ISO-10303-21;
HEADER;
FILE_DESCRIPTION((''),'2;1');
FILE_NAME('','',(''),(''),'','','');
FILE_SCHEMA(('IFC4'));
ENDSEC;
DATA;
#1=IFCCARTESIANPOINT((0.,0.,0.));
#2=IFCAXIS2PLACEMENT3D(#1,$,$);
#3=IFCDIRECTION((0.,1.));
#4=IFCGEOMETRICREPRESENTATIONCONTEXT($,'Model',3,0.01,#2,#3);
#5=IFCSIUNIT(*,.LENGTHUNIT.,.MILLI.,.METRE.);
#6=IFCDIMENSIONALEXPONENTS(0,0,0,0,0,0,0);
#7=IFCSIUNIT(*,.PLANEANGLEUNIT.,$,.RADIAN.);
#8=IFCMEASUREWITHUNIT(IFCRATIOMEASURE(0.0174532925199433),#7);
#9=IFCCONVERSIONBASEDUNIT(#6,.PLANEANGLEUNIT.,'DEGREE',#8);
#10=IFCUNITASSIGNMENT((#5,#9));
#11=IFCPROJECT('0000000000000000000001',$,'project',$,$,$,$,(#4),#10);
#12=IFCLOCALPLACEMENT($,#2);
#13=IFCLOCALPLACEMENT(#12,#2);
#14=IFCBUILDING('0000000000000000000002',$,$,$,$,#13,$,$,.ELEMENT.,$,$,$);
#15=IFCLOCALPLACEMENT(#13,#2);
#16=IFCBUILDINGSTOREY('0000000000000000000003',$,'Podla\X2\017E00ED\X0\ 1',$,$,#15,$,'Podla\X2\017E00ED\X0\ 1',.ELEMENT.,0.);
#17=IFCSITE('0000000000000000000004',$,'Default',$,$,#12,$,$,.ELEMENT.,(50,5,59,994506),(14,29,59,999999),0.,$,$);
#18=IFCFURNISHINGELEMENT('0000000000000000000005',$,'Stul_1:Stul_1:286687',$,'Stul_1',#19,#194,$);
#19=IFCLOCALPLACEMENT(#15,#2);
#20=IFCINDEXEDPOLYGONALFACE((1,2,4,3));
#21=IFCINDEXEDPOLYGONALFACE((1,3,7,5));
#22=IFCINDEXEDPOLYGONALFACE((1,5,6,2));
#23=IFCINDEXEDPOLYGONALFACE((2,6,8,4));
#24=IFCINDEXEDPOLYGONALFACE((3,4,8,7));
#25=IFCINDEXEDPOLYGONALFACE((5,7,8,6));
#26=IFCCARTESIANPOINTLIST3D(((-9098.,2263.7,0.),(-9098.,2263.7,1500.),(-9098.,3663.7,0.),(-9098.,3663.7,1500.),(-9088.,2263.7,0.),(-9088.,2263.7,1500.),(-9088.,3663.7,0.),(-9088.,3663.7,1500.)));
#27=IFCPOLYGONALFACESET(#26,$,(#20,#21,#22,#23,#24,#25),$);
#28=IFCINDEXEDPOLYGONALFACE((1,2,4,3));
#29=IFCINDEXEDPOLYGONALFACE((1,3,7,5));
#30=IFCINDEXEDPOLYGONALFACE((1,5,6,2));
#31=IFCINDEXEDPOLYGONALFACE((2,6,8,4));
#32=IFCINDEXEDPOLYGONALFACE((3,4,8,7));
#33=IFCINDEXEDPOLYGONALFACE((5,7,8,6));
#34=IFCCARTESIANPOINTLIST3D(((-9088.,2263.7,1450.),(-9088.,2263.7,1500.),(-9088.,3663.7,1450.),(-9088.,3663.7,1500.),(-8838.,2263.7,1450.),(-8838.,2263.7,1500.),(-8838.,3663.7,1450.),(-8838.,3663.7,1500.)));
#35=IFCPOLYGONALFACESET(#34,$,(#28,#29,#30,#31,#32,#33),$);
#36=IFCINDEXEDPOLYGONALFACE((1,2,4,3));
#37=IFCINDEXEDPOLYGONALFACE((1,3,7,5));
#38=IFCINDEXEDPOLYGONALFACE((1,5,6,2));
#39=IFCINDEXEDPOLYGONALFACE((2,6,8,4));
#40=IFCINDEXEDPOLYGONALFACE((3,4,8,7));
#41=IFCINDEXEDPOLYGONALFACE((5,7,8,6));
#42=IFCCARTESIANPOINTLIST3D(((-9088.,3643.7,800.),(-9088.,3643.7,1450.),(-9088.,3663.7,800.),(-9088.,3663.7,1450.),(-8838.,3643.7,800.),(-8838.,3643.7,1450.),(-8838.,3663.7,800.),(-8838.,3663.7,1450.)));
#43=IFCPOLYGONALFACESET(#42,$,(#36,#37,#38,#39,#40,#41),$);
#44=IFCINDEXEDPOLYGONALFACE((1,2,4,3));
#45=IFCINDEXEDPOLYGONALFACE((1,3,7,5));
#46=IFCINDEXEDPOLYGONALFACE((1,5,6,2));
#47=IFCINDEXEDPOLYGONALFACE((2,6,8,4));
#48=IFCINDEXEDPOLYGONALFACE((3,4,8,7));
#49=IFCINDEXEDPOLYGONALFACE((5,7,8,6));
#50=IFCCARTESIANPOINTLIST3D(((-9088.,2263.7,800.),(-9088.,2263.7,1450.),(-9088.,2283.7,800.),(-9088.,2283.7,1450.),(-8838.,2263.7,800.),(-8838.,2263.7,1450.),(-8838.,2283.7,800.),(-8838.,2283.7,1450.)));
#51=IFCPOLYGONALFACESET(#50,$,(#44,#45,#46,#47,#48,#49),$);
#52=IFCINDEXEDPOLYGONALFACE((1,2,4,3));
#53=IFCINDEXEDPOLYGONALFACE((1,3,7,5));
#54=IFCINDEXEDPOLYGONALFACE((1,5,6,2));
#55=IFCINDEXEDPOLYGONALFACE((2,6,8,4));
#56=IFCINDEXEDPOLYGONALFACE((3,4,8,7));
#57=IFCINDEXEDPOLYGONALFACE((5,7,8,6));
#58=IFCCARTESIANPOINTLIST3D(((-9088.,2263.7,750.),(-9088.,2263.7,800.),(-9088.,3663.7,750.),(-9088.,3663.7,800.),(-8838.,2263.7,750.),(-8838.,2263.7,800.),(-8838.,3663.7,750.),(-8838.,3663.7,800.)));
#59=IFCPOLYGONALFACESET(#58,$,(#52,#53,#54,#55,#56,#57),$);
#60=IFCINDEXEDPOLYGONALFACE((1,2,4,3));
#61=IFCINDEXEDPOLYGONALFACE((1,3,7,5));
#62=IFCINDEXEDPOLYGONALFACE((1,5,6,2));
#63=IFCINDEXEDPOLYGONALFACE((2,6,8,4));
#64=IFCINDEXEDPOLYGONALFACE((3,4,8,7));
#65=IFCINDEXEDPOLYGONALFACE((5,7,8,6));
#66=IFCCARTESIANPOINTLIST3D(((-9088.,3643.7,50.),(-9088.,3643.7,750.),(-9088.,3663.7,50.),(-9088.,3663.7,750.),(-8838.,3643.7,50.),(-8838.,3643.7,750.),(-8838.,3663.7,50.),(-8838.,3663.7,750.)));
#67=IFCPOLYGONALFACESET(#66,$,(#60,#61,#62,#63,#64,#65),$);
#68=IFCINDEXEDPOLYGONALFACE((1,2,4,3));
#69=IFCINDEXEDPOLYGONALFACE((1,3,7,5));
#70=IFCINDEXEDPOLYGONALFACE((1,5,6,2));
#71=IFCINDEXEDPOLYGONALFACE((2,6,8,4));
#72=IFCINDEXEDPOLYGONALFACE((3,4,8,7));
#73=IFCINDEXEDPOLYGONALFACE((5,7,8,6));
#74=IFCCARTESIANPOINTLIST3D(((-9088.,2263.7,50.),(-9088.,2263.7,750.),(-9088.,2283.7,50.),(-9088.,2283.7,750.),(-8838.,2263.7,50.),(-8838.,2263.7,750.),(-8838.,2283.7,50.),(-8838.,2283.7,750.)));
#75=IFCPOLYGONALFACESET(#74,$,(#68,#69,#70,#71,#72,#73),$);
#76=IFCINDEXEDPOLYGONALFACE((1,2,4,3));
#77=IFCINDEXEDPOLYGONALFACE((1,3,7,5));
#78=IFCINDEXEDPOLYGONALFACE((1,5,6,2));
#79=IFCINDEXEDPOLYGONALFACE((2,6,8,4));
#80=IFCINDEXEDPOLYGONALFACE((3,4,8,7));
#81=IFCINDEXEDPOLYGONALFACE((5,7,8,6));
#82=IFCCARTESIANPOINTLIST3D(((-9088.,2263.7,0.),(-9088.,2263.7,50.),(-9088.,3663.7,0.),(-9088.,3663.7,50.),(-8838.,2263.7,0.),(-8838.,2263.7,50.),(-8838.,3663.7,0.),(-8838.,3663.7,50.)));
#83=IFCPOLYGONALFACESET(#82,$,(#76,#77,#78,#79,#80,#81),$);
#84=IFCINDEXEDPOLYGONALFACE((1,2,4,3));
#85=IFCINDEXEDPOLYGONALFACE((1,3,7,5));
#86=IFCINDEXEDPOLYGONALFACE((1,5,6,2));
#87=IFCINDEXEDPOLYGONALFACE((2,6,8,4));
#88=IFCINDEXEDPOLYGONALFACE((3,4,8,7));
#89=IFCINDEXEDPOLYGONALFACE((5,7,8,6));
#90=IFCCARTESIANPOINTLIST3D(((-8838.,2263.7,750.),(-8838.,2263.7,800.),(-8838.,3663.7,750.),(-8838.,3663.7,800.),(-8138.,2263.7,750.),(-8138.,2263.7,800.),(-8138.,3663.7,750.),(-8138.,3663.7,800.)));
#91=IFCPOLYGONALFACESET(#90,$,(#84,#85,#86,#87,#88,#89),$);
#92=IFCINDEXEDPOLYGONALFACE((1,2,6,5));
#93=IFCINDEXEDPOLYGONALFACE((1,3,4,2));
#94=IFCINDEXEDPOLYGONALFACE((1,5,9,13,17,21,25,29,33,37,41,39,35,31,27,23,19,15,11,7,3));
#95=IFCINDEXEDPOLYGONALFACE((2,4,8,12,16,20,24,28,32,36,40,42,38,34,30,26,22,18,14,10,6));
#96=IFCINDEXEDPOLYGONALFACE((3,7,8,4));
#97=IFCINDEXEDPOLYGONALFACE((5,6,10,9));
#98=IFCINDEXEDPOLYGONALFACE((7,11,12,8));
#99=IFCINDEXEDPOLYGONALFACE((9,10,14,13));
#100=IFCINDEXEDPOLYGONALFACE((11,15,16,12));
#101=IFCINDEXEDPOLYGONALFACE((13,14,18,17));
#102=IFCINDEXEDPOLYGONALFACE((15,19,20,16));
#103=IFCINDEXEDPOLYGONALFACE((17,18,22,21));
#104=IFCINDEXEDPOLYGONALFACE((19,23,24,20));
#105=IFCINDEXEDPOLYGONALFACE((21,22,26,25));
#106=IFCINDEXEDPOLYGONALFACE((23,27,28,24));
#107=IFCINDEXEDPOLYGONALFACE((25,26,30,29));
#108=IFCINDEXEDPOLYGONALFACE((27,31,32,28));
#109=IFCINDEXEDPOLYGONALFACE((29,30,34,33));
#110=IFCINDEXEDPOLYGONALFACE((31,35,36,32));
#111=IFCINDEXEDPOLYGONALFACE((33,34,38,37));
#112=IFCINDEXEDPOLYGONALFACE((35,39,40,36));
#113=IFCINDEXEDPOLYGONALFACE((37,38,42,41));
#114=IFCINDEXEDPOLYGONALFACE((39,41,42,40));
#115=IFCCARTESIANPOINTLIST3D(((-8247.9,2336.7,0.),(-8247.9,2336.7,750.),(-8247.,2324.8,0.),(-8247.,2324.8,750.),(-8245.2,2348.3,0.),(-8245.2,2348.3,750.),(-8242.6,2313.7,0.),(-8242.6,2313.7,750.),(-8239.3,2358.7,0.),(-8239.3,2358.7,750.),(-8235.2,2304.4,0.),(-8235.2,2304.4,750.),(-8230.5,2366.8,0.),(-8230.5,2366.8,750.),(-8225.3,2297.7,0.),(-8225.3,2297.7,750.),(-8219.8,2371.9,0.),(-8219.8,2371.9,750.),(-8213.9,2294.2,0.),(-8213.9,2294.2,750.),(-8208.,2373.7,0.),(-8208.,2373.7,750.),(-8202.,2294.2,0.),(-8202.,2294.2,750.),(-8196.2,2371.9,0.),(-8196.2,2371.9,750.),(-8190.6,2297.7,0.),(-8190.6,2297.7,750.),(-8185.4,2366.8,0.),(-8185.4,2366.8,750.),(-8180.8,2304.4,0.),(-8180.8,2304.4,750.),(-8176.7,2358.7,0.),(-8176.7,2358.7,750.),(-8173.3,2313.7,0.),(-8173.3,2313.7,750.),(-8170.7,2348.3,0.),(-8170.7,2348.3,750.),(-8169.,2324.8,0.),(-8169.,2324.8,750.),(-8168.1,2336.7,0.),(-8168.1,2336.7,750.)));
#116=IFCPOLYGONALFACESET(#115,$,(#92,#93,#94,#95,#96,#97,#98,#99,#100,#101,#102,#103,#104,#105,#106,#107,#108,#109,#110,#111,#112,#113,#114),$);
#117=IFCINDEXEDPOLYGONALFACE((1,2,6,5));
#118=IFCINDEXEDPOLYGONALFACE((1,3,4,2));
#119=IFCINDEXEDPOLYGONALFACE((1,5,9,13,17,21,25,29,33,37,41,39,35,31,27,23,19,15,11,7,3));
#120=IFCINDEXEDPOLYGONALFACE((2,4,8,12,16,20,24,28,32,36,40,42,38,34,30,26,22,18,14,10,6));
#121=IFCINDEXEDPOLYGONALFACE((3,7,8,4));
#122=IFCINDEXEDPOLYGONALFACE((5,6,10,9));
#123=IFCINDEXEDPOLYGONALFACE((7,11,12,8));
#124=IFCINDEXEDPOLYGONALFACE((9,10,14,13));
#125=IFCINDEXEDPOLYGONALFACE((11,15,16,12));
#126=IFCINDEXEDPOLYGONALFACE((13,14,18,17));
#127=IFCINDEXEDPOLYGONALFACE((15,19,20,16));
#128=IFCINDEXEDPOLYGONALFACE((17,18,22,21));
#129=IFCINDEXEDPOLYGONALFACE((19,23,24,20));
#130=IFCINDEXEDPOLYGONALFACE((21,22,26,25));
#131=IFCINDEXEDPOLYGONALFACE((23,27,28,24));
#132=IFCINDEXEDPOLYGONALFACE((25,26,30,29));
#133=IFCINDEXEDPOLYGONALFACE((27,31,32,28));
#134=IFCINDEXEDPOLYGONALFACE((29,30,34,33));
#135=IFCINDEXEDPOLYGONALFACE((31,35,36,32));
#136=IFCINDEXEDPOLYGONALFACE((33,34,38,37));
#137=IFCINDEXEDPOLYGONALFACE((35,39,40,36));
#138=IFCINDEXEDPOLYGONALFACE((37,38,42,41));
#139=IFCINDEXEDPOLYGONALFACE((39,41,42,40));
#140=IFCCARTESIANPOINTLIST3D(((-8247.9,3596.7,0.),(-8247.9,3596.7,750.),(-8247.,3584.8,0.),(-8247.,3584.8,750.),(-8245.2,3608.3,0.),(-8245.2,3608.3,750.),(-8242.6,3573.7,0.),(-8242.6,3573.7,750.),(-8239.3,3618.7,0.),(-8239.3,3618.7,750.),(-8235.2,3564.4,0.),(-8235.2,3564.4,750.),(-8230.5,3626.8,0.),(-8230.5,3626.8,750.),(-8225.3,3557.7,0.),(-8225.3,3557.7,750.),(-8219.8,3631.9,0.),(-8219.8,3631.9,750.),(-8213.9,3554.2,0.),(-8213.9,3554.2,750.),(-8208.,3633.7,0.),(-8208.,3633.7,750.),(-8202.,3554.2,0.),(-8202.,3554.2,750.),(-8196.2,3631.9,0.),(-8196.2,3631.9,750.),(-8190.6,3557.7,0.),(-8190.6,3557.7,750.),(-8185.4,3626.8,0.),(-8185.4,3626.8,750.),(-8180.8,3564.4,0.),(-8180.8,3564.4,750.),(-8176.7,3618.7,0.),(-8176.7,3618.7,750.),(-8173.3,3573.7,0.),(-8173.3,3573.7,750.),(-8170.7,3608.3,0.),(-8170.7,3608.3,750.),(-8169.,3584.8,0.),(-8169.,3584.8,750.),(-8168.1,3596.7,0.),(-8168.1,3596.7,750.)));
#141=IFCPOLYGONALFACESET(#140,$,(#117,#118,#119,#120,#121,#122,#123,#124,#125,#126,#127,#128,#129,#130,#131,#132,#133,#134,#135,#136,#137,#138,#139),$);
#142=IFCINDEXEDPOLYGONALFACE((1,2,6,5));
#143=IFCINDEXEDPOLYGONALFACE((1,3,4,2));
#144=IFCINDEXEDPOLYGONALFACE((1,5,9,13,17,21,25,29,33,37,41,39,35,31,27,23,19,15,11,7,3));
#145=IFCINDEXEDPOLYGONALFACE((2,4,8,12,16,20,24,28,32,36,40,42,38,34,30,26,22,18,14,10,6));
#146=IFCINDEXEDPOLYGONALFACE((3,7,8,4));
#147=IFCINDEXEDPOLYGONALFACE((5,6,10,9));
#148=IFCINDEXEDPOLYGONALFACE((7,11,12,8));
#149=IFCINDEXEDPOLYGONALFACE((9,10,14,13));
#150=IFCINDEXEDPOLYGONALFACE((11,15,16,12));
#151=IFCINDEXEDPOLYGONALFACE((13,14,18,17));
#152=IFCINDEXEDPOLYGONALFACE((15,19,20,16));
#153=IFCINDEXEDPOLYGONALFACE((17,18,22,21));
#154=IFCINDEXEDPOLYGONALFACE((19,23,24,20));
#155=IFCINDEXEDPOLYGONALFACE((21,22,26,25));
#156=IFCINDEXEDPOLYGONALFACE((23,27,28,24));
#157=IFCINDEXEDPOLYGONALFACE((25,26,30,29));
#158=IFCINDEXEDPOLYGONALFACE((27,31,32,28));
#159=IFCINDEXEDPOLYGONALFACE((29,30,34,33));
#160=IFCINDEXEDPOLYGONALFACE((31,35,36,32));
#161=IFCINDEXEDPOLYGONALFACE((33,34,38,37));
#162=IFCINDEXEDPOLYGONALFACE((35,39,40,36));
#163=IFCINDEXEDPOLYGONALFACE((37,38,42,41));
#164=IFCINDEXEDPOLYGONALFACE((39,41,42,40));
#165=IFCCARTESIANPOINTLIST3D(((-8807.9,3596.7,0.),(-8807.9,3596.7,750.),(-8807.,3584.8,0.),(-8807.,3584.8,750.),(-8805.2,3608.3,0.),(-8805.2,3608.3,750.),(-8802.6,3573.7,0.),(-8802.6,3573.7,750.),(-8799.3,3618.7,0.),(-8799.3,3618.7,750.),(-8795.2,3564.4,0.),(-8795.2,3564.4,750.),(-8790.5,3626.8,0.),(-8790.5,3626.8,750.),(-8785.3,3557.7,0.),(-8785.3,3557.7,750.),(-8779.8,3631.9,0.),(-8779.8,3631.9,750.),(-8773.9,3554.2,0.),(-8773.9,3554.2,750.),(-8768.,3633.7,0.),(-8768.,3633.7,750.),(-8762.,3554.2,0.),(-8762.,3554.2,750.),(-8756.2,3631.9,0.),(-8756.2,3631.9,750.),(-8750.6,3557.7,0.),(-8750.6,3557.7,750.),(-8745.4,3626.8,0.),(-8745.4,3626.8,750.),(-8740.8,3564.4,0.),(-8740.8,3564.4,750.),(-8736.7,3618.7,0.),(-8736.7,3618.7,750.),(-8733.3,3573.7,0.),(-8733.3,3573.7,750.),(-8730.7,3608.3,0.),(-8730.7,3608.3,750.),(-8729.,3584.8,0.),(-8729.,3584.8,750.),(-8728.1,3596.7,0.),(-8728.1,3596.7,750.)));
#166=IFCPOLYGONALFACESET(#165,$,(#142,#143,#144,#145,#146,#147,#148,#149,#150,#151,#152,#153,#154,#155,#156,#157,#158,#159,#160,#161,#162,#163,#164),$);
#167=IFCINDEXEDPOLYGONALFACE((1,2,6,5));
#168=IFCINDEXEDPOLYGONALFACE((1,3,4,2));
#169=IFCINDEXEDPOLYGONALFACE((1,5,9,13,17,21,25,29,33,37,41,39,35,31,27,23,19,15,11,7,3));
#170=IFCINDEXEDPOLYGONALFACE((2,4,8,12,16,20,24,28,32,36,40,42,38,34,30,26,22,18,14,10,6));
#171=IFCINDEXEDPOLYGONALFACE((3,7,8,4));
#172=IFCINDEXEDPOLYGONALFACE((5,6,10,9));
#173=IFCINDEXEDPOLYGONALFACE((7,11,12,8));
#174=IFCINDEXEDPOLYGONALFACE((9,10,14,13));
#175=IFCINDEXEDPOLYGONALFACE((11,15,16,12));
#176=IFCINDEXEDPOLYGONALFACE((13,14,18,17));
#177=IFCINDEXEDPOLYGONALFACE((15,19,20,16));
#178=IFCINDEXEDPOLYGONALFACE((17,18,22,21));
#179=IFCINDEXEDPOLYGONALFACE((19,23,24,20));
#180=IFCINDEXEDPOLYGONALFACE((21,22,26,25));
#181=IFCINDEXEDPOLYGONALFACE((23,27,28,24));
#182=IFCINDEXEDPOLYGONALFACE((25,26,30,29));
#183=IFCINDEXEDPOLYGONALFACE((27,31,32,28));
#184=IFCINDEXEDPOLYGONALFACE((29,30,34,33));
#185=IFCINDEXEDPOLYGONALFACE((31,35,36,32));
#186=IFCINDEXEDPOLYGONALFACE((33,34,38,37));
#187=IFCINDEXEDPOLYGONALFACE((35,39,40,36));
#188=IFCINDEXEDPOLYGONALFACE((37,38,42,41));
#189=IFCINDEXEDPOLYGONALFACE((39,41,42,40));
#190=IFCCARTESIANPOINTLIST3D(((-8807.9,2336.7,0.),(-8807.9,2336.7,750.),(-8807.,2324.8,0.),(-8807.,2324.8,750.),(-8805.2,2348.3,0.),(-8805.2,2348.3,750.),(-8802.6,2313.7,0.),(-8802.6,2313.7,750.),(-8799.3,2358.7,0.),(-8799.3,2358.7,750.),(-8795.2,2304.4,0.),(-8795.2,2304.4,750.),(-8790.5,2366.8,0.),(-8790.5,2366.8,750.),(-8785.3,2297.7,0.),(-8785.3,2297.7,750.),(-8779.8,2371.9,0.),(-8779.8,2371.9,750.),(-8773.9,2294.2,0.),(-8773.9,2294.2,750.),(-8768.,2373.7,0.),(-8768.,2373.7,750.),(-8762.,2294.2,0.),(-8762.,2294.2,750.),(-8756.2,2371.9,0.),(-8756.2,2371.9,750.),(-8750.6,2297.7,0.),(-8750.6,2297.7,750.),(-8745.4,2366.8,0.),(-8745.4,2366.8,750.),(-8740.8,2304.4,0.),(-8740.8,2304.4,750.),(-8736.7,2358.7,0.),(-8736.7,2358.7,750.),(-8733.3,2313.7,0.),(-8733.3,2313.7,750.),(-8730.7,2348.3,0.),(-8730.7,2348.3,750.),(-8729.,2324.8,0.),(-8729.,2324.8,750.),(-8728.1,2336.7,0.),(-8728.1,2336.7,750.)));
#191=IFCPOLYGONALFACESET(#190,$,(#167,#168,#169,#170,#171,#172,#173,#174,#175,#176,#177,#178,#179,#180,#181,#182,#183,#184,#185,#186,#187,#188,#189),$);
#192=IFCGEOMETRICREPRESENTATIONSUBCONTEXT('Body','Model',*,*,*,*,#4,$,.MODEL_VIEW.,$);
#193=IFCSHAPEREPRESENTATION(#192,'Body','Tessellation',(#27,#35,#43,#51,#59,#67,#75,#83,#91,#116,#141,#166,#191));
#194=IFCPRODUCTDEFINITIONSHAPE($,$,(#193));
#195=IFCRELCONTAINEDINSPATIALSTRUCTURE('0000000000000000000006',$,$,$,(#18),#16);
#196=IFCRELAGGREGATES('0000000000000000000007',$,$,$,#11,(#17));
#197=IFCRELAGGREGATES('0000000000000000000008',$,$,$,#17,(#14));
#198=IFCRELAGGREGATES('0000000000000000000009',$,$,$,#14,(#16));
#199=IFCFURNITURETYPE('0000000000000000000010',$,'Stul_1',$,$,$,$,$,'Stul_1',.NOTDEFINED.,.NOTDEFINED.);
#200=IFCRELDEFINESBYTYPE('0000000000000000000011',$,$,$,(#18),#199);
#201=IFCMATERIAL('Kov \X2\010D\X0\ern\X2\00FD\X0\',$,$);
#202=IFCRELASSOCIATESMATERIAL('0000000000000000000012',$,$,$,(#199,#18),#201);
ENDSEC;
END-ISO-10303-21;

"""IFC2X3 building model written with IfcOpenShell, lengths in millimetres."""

from ifc_helpers import new_model, entity, si_unit, converted_unit, direction, frame, frame_2d, origin, origin_2d_with_axis, place, context, subcontext, project, spatial, rectangle, circle, extrude, source, transform, mapped, material, type_object, type_shapes, element, save


model = new_model("IFC2X3")

# Units and contexts
model_context = context("Model", 3, precision=0.01, world=origin(), true_north=direction((0.0, 1.0)))
body_context = subcontext(model_context, "Body", "Model", "MODEL_VIEW")
ifc_project = project(units=[si_unit("LENGTHUNIT", "METRE", prefix="MILLI"), converted_unit("PLANEANGLEUNIT", "DEGREE", entity("IfcRatioMeasure", 0.0174532925199433), si_unit("PLANEANGLEUNIT", "RADIAN"), dimensions=[0, 0, 0, 0, 0, 0, 0])], contexts=[model_context])

# Site, building, storey
site_placement = place(None, origin())
site = spatial("IfcSite", under=ifc_project, at=site_placement, Name="Default", CompositionType="ELEMENT", RefLatitude=(50, 5, 59, 994506), RefLongitude=(14, 29, 59, 999999), RefElevation=0.0)
building_placement = place(site_placement, origin())
building = spatial("IfcBuilding", under=site, at=building_placement, CompositionType="ELEMENT")
storey_placement = place(building_placement, origin())
storey = spatial("IfcBuildingStorey", under=building, at=storey_placement, Name="Podlaží 1", LongName="Podlaží 1", CompositionType="ELEMENT", Elevation=0.0)

# Furnishing element
ifc_material_1 = material(Name="Kov černý")
furniture_type = type_object("IfcFurnitureType", Name="Stul_1", ElementType="Stul_1", material=ifc_material_1)
shared_shape_1 = source(origin(), body_context, "Body", "SweptSolid", [
    extrude(rectangle(XDim=1400.0, YDim=10.0, at=origin_2d_with_axis()), frame((0.0, 605.0, 0.0), z_axis=(0.0, 0.0, 1.0), x_axis=(-1.0, 0.0, 0.0)), (0.0, 0.0, 1.0), 1500.0),
    extrude(rectangle(XDim=1400.0, YDim=250.0, at=frame_2d((0.0, 0.0), x_axis=(1.0, 0.0))), frame((0.0, 475.0, 1450.0), z_axis=(0.0, 0.0, 1.0), x_axis=(-1.0, 0.0, 0.0)), (0.0, 0.0, 1.0), 50.0),
    extrude(rectangle(XDim=20.0, YDim=250.0, at=origin_2d_with_axis()), frame((690.0, 475.0, 800.0), z_axis=(0.0, 0.0, 1.0), x_axis=(-1.0, 0.0, 0.0)), (0.0, 0.0, 1.0), 650.0),
    extrude(rectangle(XDim=20.0, YDim=250.0, at=frame_2d((0.0, 0.0), x_axis=(1.0, 0.0))), frame((-690.0, 475.0, 800.0), z_axis=(0.0, 0.0, 1.0), x_axis=(-1.0, 0.0, 0.0)), (0.0, 0.0, 1.0), 650.0),
    extrude(rectangle(XDim=1400.0, YDim=250.0, at=origin_2d_with_axis()), frame((0.0, 475.0, 750.0), z_axis=(0.0, 0.0, 1.0), x_axis=(-1.0, 0.0, 0.0)), (0.0, 0.0, 1.0), 50.0),
    extrude(rectangle(XDim=20.0, YDim=250.0, at=origin_2d_with_axis()), frame((690.0, 475.0, 50.0), z_axis=(0.0, 0.0, 1.0), x_axis=(-1.0, 0.0, 0.0)), (0.0, 0.0, 1.0), 700.0),
    extrude(rectangle(XDim=20.0, YDim=250.0, at=frame_2d((0.0, 0.0), x_axis=(1.0, 0.0))), frame((-690.0, 475.0, 50.0), z_axis=(0.0, 0.0, 1.0), x_axis=(-1.0, 0.0, 0.0)), (0.0, 0.0, 1.0), 700.0),
    extrude(rectangle(XDim=1400.0, YDim=250.0, at=origin_2d_with_axis()), frame((0.0, 475.0, 0.0), z_axis=(0.0, 0.0, 1.0), x_axis=(-1.0, 0.0, 0.0)), (0.0, 0.0, 1.0), 50.0),
    extrude(rectangle(XDim=1400.0, YDim=700.0, at=origin_2d_with_axis()), frame((0.0, 0.0, 750.0), z_axis=(0.0, 0.0, 1.0), x_axis=(-1.0, 0.0, 0.0)), (0.0, 0.0, 1.0), 50.0),
    extrude(circle(Radius=40.0, at=frame_2d((0.0, 0.0), x_axis=(1.0, 0.0))), frame((-630.0, -280.0, 0.0)), (0.0, 0.0, 1.0), 750.0),
    extrude(circle(Radius=40.0, at=frame_2d((0.0, 0.0), x_axis=(1.0, 0.0))), frame((630.0, -280.0, 0.0)), (0.0, 0.0, 1.0), 750.0),
    extrude(circle(Radius=40.0, at=frame_2d((0.0, 0.0), x_axis=(1.0, 0.0))), frame((630.0, 280.0, 0.0)), (0.0, 0.0, 1.0), 750.0),
    extrude(circle(Radius=40.0, at=frame_2d((0.0, 0.0), x_axis=(1.0, 0.0))), frame((-630.0, 280.0, 0.0)), (0.0, 0.0, 1.0), 750.0),
])
type_shapes(furniture_type, [shared_shape_1])
for number, where, z_axis, x_axis, name in (
    (1, (-8488.0, 2963.7, 0.0), (0.0, 0.0, 1.0), (0.0, 1.0, 0.0), "Stul_1:Stul_1:286687"),
):
    element("IfcFurnishingElement", number, at=place(storey_placement, frame(where, z_axis=z_axis, x_axis=x_axis)), inside=storey, type_object=furniture_type, material=ifc_material_1, Name=name, ObjectType="Stul_1", context=body_context, shape_type="MappedRepresentation", body=[
        mapped(shared_shape_1, transform((0.0, 0.0, 0.0), scale=1.0)),
    ])

save(model, "model.ifc")
